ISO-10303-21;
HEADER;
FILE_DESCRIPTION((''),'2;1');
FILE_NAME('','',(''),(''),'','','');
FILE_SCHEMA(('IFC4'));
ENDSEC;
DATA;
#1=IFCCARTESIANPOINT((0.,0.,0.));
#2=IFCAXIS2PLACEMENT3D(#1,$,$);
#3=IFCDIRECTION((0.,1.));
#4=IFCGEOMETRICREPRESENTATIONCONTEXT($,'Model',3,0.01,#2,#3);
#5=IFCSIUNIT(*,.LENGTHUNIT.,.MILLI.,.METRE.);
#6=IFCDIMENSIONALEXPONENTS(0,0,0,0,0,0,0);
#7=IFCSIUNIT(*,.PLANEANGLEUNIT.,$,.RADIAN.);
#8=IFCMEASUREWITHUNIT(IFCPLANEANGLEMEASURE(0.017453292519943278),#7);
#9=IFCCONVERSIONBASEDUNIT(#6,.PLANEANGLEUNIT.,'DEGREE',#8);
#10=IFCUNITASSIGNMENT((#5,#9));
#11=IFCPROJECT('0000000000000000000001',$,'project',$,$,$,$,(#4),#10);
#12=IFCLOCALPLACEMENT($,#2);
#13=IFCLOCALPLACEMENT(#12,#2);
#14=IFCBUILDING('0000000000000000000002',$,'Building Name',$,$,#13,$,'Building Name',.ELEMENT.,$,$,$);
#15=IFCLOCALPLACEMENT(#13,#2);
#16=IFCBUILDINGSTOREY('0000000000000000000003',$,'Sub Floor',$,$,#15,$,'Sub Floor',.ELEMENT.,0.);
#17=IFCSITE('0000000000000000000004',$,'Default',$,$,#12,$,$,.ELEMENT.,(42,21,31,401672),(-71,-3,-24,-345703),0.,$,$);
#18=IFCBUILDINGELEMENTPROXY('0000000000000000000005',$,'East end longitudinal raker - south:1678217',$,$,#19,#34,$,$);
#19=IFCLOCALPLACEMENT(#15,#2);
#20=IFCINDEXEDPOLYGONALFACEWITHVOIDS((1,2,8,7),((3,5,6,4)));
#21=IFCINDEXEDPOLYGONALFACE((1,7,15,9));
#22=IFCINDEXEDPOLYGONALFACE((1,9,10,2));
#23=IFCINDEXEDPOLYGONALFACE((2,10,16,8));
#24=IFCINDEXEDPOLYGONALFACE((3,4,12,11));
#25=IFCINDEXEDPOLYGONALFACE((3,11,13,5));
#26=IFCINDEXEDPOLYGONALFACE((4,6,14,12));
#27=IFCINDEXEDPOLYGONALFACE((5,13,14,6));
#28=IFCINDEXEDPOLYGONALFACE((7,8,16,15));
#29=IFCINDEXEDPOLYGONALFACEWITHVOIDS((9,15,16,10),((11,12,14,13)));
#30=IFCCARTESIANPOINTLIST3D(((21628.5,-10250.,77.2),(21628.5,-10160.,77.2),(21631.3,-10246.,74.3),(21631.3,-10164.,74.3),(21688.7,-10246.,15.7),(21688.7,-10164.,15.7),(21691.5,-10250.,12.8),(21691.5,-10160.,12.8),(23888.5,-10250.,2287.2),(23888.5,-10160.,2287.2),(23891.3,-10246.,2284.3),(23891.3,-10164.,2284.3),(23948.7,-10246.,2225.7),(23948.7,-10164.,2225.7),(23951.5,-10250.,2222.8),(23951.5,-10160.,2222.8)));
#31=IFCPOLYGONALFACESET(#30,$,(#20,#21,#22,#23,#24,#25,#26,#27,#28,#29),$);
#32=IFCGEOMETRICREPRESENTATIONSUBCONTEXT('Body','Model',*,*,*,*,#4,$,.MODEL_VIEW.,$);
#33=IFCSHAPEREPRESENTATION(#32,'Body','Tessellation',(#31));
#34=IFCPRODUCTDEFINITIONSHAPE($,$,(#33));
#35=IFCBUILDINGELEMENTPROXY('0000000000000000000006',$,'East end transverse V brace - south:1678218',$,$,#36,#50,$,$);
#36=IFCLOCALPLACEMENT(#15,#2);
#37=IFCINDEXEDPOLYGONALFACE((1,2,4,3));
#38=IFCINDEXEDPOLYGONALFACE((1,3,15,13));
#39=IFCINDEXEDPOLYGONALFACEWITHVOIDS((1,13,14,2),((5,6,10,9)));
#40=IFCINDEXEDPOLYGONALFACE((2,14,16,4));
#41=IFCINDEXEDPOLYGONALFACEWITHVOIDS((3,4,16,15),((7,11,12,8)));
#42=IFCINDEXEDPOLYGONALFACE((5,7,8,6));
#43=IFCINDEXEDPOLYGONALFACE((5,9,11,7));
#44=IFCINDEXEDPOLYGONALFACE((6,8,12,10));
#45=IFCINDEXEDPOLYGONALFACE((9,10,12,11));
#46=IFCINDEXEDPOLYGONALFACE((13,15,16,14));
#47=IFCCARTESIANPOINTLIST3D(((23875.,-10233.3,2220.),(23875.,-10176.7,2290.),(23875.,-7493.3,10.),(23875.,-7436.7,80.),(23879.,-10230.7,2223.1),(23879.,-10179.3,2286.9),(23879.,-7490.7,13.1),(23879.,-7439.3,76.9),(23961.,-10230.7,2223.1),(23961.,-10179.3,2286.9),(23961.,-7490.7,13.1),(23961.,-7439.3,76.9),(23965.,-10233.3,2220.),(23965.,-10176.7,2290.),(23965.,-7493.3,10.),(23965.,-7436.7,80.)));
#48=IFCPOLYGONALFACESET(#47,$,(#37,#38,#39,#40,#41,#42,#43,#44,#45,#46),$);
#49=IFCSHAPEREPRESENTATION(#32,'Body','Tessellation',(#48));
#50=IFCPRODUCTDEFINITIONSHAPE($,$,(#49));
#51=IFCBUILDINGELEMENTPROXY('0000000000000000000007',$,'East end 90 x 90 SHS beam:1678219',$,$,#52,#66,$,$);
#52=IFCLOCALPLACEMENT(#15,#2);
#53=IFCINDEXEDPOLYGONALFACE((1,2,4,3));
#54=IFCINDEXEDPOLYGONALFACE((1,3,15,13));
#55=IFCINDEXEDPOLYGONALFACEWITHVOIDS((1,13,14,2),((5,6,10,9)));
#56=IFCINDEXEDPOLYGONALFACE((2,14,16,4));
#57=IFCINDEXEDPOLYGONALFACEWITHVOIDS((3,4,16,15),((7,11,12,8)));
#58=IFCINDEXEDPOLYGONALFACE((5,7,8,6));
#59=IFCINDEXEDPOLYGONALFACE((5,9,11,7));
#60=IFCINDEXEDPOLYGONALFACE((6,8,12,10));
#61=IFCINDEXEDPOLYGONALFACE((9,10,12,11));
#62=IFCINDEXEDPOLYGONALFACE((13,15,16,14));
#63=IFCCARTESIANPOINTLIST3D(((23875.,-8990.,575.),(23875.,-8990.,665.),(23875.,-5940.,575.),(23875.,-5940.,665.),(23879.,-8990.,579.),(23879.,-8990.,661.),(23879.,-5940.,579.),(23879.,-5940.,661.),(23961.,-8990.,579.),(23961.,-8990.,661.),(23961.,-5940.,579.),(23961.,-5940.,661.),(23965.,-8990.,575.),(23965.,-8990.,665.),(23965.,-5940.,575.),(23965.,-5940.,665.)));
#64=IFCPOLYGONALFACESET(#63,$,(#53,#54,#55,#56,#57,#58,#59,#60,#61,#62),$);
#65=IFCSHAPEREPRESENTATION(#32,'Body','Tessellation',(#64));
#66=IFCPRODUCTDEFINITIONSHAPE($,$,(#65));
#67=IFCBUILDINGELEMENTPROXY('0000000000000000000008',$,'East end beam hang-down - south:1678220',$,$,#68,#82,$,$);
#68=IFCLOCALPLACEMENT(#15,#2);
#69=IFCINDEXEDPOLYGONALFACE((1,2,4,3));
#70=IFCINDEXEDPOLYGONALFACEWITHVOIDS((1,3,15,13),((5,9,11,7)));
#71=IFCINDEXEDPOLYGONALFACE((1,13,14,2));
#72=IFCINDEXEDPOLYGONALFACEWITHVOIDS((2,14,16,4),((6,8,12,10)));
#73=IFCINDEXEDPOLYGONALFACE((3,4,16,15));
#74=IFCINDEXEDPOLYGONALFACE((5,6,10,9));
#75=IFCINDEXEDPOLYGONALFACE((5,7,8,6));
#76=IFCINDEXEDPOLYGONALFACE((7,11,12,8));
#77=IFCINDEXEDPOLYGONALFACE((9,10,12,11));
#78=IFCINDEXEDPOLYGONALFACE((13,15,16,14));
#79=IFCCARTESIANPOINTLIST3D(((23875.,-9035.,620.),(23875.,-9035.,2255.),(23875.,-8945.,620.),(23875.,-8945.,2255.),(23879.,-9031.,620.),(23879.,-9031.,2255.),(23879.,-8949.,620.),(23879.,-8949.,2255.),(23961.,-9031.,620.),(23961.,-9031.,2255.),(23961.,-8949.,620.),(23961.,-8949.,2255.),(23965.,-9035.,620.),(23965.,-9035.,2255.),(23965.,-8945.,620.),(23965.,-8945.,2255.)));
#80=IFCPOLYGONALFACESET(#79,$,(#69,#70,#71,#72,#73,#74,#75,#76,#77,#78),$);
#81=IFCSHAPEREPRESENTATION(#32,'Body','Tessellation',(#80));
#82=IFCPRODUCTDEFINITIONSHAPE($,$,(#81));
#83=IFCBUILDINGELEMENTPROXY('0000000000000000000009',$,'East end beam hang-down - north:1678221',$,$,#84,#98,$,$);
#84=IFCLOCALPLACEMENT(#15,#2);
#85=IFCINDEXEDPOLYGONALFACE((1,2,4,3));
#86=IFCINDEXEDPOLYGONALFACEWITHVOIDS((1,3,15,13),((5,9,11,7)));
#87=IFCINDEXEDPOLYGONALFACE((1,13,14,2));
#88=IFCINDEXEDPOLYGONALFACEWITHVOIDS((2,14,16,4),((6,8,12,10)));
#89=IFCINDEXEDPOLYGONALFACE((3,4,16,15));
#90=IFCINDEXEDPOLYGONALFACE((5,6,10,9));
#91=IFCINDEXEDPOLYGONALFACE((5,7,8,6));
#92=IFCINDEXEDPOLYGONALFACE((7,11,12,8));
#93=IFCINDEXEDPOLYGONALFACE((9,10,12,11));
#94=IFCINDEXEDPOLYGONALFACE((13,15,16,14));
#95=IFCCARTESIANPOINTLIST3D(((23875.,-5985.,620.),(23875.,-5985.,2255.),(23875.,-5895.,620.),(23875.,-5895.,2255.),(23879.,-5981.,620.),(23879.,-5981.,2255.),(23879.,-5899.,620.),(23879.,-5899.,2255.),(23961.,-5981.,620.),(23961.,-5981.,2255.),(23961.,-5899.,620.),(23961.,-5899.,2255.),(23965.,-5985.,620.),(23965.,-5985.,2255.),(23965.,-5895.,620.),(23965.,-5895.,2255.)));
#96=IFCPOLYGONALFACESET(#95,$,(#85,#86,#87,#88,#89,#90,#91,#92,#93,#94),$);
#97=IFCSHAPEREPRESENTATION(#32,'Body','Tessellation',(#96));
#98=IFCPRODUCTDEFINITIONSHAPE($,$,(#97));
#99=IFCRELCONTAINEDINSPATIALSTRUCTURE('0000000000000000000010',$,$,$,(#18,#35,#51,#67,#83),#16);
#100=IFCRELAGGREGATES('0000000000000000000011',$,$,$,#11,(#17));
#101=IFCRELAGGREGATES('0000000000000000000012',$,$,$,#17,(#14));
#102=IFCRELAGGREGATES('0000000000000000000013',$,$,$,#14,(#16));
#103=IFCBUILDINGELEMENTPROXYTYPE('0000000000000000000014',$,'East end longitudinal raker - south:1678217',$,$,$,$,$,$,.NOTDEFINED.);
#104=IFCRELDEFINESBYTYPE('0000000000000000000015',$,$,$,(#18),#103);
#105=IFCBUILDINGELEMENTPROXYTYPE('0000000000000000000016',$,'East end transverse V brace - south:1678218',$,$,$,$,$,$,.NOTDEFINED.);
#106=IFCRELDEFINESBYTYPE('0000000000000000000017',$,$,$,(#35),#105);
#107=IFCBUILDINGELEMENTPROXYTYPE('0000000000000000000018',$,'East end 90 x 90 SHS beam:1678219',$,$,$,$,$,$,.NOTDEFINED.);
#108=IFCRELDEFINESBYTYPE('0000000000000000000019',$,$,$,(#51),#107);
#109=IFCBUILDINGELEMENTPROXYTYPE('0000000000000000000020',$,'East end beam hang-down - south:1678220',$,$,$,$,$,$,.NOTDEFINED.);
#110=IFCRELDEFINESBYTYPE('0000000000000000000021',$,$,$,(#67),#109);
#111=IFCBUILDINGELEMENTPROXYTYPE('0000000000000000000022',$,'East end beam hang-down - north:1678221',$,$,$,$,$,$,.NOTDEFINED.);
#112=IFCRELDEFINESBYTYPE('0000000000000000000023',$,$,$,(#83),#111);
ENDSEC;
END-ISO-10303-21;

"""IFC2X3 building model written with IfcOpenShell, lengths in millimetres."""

from ifc_helpers import new_model, entity, si_unit, converted_unit, direction, frame, origin, place, context, subcontext, project, spatial, polyline, outline, extrude, type_object, element, save


model = new_model("IFC2X3")

# Units and contexts
model_context = context("Model", 3, precision=0.01, world=origin(), true_north=direction((0.0, 1.0)))
body_context = subcontext(model_context, "Body", "Model", "MODEL_VIEW")
ifc_project = project(units=[si_unit("LENGTHUNIT", "METRE", prefix="MILLI"), converted_unit("PLANEANGLEUNIT", "DEGREE", entity("IfcPlaneAngleMeasure", 0.017453292519943278), si_unit("PLANEANGLEUNIT", "RADIAN"), dimensions=[0, 0, 0, 0, 0, 0, 0])], contexts=[model_context])

# Site, building, storey
site_placement = place(None, origin())
site = spatial("IfcSite", under=ifc_project, at=site_placement, Name="Default", CompositionType="ELEMENT", RefLatitude=(42, 21, 31, 401672), RefLongitude=(-71, -3, -24, -345703), RefElevation=0.0)
building_placement = place(site_placement, origin())
building = spatial("IfcBuilding", under=site, at=building_placement, Name="Building Name", LongName="Building Name", CompositionType="ELEMENT")
storey_placement = place(building_placement, origin())
storey = spatial("IfcBuildingStorey", under=building, at=storey_placement, Name="Sub Floor", LongName="Sub Floor", CompositionType="ELEMENT", Elevation=0.0)

# Building element proxies
building_element_proxy_type_1 = type_object("IfcBuildingElementProxyType", Name="East end longitudinal raker - south:1678217", PredefinedType="NOTDEFINED")
proxy_1_placement = place(storey_placement, origin())
element("IfcBuildingElementProxy", 1, at=proxy_1_placement, inside=storey, type_object=building_element_proxy_type_1, Name="East end longitudinal raker - south:1678217", context=body_context, shape_type="SweptSolid", body=[
    extrude(outline(polyline([(-45.0, -45.0), (45.0, -45.0), (45.0, 45.0), (-45.0, 45.0), (-45.0, -45.0)]), holes=[polyline([(-41.0, -41.0), (-41.0, 41.0), (41.0, 41.0), (41.0, -41.0), (-41.0, -41.0)])]), frame((21660.0, -10205.0, 45.0), z_axis=(0.714972, 0.0, 0.699154), x_axis=(0.0, -1.0, 0.0)), (0.0, 0.0, 1.0), 3161.0),
])
building_element_proxy_type_2 = type_object("IfcBuildingElementProxyType", Name="East end transverse V brace - south:1678218", PredefinedType="NOTDEFINED")
proxy_2_placement = place(storey_placement, origin())
element("IfcBuildingElementProxy", 2, at=proxy_2_placement, inside=storey, type_object=building_element_proxy_type_2, Name="East end transverse V brace - south:1678218", context=body_context, shape_type="SweptSolid", body=[
    extrude(outline(polyline([(-45.0, -45.0), (45.0, -45.0), (45.0, 45.0), (-45.0, 45.0), (-45.0, -45.0)]), holes=[polyline([(-41.0, -41.0), (-41.0, 41.0), (41.0, 41.0), (41.0, -41.0), (-41.0, -41.0)])]), frame((23920.0, -10205.0, 2255.0), z_axis=(0.0, 0.778368, -0.627808), x_axis=(0.0, -0.627808, -0.778368)), (0.0, 0.0, 1.0), 3520.2),
])
building_element_proxy_type_3 = type_object("IfcBuildingElementProxyType", Name="East end 90 x 90 SHS beam:1678219", PredefinedType="NOTDEFINED")
proxy_3_placement = place(storey_placement, origin())
element("IfcBuildingElementProxy", 3, at=proxy_3_placement, inside=storey, type_object=building_element_proxy_type_3, Name="East end 90 x 90 SHS beam:1678219", context=body_context, shape_type="SweptSolid", body=[
    extrude(outline(polyline([(-45.0, -45.0), (45.0, -45.0), (45.0, 45.0), (-45.0, 45.0), (-45.0, -45.0)]), holes=[polyline([(-41.0, -41.0), (-41.0, 41.0), (41.0, 41.0), (41.0, -41.0), (-41.0, -41.0)])]), frame((23920.0, -8990.0, 620.0), z_axis=(0.0, 1.0, 0.0), x_axis=(1.0, 0.0, 0.0)), (0.0, 0.0, 1.0), 3050.0),
])
building_element_proxy_type_4 = type_object("IfcBuildingElementProxyType", Name="East end beam hang-down - south:1678220", PredefinedType="NOTDEFINED")
proxy_4_placement = place(storey_placement, origin())
element("IfcBuildingElementProxy", 4, at=proxy_4_placement, inside=storey, type_object=building_element_proxy_type_4, Name="East end beam hang-down - south:1678220", context=body_context, shape_type="SweptSolid", body=[
    extrude(outline(polyline([(-45.0, -45.0), (45.0, -45.0), (45.0, 45.0), (-45.0, 45.0), (-45.0, -45.0)]), holes=[polyline([(-41.0, -41.0), (-41.0, 41.0), (41.0, 41.0), (41.0, -41.0), (-41.0, -41.0)])]), frame((23920.0, -8990.0, 620.0), z_axis=(0.0, 0.0, 1.0), x_axis=(0.0, 1.0, 0.0)), (0.0, 0.0, 1.0), 1635.0),
])
building_element_proxy_type_5 = type_object("IfcBuildingElementProxyType", Name="East end beam hang-down - north:1678221", PredefinedType="NOTDEFINED")
proxy_5_placement = place(storey_placement, origin())
element("IfcBuildingElementProxy", 5, at=proxy_5_placement, inside=storey, type_object=building_element_proxy_type_5, Name="East end beam hang-down - north:1678221", context=body_context, shape_type="SweptSolid", body=[
    extrude(outline(polyline([(-45.0, -45.0), (45.0, -45.0), (45.0, 45.0), (-45.0, 45.0), (-45.0, -45.0)]), holes=[polyline([(-41.0, -41.0), (-41.0, 41.0), (41.0, 41.0), (41.0, -41.0), (-41.0, -41.0)])]), frame((23920.0, -5940.0, 620.0), z_axis=(0.0, 0.0, 1.0), x_axis=(0.0, 1.0, 0.0)), (0.0, 0.0, 1.0), 1635.0),
])

save(model, "model.ifc")
